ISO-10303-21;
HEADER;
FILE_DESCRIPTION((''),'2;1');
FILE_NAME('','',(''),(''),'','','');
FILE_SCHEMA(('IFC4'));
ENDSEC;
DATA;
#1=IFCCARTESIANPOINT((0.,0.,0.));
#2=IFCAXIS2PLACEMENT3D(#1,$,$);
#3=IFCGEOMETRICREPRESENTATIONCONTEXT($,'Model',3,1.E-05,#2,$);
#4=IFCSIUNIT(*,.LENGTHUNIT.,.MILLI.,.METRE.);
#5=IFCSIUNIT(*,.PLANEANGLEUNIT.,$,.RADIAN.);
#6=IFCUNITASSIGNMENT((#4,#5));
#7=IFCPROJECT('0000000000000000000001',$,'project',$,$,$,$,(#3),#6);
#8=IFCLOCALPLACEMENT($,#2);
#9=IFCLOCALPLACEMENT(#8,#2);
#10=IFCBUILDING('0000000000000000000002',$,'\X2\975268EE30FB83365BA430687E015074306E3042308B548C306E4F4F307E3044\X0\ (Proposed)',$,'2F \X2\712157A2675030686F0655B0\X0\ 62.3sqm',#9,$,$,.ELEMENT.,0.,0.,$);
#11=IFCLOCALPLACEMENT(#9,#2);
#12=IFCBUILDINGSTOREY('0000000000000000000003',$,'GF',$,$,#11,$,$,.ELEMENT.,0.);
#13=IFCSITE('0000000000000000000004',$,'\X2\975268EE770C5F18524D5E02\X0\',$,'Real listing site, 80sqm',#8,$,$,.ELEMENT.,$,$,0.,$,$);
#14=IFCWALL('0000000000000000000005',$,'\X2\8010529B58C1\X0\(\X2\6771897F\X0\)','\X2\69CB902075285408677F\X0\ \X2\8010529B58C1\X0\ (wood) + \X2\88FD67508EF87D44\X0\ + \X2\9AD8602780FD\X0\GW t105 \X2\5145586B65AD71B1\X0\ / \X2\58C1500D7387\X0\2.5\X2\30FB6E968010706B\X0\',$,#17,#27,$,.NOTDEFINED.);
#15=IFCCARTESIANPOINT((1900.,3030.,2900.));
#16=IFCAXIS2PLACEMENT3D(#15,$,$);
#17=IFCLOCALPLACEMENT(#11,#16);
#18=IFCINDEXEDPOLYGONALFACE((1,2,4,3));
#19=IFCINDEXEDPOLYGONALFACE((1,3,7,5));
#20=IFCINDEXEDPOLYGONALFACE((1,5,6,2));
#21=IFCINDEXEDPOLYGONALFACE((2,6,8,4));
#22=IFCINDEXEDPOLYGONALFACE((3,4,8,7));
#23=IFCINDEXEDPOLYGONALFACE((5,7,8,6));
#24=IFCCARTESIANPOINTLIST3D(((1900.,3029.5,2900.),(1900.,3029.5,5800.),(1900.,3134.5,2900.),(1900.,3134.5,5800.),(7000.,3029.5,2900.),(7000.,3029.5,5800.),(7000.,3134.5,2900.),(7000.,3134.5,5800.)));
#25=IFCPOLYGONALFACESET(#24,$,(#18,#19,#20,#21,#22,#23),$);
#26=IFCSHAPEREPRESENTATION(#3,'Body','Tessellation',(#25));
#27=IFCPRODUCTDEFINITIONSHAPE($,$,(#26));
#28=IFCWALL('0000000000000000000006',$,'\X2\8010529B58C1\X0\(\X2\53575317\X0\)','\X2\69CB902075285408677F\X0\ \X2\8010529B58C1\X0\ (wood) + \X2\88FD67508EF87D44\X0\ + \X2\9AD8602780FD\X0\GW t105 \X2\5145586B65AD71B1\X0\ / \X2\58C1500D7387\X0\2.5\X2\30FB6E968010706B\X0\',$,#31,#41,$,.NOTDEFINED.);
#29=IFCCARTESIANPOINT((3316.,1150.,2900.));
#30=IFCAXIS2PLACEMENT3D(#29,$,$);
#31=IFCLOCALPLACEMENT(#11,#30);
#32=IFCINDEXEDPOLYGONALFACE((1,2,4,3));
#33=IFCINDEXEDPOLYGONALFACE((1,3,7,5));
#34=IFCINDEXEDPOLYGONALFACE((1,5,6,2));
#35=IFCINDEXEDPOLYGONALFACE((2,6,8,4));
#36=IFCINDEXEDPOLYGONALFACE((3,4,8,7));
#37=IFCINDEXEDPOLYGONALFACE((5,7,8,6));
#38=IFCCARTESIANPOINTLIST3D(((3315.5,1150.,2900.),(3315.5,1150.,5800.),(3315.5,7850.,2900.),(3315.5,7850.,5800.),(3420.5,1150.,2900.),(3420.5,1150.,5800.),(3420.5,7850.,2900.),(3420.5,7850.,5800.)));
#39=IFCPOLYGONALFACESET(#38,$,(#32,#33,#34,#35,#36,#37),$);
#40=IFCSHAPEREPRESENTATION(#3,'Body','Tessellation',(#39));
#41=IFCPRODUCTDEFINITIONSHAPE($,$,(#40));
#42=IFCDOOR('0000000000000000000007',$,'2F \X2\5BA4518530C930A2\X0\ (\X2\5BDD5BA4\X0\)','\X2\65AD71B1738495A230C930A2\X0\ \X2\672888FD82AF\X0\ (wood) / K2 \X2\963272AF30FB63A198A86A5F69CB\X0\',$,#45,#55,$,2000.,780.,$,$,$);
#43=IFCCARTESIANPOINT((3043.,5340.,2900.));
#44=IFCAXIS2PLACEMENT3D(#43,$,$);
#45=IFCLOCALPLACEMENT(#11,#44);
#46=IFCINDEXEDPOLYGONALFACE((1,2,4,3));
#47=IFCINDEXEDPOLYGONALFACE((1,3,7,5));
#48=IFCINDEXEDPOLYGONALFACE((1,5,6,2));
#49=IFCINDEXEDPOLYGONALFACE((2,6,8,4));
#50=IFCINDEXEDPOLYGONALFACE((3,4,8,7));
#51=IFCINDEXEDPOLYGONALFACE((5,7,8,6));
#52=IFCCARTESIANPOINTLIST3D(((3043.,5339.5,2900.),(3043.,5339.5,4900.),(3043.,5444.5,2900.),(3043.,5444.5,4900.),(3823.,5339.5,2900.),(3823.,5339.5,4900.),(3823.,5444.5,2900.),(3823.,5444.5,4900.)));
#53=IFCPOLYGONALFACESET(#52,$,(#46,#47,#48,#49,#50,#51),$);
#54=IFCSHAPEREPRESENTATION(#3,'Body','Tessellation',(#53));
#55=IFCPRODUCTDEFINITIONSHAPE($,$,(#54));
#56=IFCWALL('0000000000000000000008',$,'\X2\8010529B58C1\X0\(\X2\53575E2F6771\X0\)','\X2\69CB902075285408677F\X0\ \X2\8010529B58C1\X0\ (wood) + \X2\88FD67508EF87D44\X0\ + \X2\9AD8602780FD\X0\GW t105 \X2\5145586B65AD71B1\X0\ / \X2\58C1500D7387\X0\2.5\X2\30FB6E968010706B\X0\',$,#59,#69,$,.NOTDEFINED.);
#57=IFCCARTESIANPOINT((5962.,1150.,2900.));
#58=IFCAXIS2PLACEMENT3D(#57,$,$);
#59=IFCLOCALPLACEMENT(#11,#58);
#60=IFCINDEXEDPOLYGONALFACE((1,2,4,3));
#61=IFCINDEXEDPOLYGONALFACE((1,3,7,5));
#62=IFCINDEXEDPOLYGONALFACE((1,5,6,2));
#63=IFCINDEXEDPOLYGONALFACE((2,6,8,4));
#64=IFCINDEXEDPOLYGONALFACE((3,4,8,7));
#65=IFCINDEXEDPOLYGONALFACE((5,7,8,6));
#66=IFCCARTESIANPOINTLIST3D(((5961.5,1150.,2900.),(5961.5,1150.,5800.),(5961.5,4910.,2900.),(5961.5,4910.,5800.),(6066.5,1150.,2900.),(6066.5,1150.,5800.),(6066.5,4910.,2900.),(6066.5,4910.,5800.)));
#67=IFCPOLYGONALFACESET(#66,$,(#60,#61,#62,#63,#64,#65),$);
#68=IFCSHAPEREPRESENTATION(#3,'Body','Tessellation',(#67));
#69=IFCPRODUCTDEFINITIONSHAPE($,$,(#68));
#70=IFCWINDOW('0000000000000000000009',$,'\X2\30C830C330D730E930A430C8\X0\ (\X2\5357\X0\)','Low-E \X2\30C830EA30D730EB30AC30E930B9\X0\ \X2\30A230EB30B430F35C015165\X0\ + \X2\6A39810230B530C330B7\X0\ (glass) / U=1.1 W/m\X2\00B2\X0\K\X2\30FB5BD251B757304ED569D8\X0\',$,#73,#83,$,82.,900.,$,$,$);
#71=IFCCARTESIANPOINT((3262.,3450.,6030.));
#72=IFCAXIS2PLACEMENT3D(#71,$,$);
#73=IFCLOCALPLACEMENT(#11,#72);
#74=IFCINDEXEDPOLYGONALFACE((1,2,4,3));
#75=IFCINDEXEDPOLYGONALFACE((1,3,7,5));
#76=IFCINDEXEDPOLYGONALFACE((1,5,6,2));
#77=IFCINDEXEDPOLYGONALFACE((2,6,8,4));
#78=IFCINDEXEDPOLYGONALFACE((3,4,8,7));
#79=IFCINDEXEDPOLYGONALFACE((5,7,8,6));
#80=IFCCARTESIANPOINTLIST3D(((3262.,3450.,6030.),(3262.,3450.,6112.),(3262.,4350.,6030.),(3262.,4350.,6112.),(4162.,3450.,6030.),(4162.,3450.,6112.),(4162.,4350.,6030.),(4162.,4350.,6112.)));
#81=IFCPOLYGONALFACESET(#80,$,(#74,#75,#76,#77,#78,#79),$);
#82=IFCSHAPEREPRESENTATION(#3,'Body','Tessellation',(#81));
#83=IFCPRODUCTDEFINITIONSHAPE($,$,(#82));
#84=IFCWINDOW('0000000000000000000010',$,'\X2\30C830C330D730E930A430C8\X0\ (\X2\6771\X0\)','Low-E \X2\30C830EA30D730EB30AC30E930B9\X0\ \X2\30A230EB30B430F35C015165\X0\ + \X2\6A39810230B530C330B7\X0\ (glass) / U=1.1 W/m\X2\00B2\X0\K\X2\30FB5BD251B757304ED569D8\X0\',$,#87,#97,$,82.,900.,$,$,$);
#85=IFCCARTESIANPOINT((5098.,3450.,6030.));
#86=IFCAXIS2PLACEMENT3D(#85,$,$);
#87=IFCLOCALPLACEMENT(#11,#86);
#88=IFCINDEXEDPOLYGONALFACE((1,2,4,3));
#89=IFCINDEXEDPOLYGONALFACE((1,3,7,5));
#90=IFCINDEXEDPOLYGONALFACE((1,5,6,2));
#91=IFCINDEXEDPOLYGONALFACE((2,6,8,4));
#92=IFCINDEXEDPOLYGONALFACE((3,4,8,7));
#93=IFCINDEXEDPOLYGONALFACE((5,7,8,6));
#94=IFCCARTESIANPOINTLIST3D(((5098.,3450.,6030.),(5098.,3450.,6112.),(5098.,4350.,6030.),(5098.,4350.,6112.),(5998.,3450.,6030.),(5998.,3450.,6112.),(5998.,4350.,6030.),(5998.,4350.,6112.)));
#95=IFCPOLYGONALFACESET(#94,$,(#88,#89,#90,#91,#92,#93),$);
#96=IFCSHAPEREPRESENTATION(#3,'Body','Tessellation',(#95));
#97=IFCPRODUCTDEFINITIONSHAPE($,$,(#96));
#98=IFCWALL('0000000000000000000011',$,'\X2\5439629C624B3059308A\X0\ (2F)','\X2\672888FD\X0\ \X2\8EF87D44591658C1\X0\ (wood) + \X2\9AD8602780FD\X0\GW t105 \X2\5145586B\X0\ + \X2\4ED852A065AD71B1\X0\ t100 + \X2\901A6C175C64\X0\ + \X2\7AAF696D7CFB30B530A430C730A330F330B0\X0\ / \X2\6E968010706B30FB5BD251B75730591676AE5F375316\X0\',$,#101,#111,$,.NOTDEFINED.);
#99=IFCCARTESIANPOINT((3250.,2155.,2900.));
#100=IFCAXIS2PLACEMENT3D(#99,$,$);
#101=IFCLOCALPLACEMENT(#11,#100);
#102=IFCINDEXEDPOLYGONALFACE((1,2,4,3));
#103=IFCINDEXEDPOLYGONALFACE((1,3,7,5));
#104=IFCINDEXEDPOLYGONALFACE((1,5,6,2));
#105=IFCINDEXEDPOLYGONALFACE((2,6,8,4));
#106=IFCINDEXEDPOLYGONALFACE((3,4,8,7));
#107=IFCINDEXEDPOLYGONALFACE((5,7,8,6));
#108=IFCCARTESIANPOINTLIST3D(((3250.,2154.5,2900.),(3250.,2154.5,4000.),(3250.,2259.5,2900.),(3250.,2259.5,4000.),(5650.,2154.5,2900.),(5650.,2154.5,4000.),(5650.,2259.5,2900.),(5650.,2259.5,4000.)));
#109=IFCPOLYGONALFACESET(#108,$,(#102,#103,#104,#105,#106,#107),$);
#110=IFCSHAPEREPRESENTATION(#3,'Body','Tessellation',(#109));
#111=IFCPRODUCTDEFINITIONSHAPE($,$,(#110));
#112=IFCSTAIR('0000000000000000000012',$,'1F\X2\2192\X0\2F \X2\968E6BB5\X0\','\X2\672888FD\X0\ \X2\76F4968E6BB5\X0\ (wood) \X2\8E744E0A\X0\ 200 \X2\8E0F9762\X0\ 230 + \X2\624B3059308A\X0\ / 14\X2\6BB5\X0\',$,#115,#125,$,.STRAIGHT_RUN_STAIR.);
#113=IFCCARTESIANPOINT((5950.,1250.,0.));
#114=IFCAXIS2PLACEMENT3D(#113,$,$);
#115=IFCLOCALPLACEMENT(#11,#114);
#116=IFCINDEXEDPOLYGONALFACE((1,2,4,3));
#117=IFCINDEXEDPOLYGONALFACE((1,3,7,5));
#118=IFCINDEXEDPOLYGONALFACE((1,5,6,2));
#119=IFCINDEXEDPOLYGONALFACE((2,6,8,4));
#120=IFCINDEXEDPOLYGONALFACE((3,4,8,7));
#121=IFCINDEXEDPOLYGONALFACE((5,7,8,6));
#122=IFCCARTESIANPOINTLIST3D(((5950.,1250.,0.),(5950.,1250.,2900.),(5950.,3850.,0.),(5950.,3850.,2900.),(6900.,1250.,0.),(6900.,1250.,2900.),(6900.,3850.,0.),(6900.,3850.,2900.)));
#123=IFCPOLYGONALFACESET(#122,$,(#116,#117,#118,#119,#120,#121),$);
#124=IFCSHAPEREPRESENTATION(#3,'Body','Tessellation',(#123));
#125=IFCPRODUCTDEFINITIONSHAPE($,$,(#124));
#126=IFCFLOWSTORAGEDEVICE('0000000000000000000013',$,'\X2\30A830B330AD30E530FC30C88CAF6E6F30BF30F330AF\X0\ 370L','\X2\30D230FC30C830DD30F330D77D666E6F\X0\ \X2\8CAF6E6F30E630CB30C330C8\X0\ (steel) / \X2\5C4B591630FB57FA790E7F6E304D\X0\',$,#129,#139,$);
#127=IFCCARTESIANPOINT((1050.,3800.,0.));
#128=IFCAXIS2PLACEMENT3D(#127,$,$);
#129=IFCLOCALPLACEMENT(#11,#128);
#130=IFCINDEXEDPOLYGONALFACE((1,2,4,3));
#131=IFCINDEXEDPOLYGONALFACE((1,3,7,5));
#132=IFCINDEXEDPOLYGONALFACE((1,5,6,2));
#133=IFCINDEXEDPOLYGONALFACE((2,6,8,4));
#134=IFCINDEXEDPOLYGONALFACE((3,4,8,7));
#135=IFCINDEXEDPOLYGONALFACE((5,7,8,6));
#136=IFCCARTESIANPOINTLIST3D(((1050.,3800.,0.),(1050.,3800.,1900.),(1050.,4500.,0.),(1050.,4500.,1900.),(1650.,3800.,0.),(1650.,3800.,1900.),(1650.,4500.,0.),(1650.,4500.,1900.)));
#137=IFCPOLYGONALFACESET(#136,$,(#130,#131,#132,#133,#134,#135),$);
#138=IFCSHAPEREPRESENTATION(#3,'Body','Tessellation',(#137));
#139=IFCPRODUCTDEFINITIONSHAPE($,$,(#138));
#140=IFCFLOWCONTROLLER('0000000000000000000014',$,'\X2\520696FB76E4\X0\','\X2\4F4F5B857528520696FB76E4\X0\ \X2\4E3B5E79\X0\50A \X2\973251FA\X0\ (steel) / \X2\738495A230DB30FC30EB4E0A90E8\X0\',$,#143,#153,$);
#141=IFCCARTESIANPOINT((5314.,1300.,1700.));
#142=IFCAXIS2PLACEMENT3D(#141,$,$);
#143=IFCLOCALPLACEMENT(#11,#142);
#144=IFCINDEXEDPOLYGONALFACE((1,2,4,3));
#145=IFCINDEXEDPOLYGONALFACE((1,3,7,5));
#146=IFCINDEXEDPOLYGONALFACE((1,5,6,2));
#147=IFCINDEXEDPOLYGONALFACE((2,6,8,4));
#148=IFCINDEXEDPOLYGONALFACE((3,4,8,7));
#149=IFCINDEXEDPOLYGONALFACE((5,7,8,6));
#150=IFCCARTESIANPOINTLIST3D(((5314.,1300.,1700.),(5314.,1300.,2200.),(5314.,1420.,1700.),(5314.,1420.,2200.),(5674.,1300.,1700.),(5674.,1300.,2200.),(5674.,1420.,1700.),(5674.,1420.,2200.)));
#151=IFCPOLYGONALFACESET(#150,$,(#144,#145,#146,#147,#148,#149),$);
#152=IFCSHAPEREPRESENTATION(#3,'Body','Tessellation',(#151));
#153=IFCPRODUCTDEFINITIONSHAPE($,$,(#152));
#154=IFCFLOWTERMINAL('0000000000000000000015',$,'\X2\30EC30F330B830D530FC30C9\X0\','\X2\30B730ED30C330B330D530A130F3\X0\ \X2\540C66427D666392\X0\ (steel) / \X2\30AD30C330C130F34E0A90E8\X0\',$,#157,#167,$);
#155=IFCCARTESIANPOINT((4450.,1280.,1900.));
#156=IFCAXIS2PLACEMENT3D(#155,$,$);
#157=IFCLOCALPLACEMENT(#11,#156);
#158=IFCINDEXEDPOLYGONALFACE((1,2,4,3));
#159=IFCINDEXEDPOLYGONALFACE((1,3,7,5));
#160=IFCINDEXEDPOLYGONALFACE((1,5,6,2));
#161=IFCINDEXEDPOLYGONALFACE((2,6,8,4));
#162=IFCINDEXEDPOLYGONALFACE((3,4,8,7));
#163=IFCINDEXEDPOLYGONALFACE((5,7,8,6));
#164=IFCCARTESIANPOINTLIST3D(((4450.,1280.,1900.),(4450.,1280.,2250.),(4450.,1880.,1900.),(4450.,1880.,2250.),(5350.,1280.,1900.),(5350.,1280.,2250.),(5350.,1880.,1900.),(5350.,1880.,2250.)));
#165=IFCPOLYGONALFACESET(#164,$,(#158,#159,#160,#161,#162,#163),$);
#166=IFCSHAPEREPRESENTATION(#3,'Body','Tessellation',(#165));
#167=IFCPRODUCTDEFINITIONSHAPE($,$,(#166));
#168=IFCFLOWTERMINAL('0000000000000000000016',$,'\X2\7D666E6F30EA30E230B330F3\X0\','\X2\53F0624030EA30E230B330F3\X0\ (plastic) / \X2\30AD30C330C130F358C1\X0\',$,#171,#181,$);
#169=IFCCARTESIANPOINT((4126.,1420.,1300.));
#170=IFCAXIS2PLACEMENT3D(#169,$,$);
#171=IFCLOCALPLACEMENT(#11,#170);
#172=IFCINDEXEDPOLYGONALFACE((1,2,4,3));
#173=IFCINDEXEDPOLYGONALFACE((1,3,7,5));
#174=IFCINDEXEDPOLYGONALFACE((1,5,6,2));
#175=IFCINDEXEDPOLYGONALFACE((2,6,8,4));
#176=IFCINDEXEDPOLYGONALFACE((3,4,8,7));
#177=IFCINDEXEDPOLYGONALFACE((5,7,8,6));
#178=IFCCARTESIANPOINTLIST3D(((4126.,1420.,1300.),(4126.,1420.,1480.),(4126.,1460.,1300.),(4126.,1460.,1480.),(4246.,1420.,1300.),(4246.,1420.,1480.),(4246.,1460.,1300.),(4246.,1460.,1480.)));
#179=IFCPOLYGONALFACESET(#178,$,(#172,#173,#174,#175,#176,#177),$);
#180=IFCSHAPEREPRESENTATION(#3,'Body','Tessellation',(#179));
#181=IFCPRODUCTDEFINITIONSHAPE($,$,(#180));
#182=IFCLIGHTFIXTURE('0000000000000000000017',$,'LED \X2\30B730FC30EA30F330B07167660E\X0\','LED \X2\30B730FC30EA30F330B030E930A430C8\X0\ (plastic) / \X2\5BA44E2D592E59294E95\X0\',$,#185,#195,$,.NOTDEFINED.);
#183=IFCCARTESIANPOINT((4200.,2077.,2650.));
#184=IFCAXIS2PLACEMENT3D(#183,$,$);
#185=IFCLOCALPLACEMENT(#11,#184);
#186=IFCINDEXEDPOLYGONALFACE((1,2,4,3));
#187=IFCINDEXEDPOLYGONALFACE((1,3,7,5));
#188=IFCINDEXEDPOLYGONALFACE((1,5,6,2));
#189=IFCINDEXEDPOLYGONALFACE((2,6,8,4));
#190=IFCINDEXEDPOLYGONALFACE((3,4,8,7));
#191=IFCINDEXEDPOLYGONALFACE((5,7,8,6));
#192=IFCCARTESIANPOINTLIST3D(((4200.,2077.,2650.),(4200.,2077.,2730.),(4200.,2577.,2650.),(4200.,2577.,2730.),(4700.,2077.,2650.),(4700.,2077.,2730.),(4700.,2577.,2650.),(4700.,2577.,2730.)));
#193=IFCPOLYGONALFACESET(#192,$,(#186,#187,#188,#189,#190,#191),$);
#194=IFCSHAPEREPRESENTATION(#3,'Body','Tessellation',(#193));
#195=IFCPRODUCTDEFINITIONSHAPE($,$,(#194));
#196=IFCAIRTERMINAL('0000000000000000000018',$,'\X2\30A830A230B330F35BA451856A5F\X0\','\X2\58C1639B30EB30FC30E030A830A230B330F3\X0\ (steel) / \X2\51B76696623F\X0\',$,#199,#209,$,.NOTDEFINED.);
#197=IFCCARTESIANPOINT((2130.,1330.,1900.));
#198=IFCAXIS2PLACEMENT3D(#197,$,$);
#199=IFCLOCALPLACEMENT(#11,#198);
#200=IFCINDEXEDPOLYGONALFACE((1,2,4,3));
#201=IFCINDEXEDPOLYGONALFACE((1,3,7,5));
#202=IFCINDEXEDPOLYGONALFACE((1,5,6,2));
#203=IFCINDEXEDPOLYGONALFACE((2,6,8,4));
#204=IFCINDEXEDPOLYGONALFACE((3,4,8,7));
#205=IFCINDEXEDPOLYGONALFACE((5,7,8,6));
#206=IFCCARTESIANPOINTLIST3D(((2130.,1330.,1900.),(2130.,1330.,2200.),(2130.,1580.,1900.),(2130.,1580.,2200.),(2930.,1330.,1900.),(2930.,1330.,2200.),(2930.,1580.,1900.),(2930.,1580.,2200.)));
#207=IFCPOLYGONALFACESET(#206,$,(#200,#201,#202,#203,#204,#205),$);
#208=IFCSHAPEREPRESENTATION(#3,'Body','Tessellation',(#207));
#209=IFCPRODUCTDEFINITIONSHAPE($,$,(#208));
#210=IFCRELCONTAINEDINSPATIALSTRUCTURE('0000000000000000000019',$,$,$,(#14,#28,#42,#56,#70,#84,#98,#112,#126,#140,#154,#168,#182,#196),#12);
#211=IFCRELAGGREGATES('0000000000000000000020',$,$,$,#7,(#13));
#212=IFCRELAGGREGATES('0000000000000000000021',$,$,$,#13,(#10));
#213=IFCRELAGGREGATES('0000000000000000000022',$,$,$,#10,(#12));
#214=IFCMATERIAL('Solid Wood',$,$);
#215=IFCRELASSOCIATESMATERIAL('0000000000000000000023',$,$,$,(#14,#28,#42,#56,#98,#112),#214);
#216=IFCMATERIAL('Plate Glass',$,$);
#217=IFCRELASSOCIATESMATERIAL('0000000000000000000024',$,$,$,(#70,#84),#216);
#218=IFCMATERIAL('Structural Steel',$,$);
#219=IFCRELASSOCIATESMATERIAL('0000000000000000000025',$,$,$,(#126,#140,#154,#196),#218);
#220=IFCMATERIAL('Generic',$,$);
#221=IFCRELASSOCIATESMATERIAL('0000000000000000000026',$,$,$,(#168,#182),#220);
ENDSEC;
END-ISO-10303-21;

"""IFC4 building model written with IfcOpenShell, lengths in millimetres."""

from ifc_helpers import new_model, si_unit, frame, frame_2d, origin, place, context, project, spatial, rectangle, extrude, material, element, fill, save


model = new_model("IFC4")

# Units and contexts
model_context = context("Model", 3, precision=1e-05, world=origin())
ifc_project = project(units=[si_unit("LENGTHUNIT", "METRE", prefix="MILLI"), si_unit("PLANEANGLEUNIT", "RADIAN")], contexts=[model_context])

# Site, building, storey
site_placement = place(None, origin())
site = spatial("IfcSite", under=ifc_project, at=site_placement, Name="青森県弘前市", ObjectType="Real listing site, 80sqm", CompositionType="ELEMENT", RefElevation=0.0)
building_placement = place(site_placement, origin())
building = spatial("IfcBuilding", under=site, at=building_placement, Name="青森・茶室と縁側のある和の住まい (Proposed)", ObjectType="2F 無垢材と漆喰 62.3sqm", CompositionType="ELEMENT", ElevationOfRefHeight=0.0, ElevationOfTerrain=0.0)
storey_placement = place(building_placement, origin())
storey = spatial("IfcBuildingStorey", under=building, at=storey_placement, Name="GF", CompositionType="ELEMENT", Elevation=0.0)

# Shared definitions
ifc_material_1 = material(Name="Solid Wood")

# Wall
wall_1_placement = place(storey_placement, frame((1900.0, 3030.0, 2900.0)))
element("IfcWall", 1, at=wall_1_placement, inside=storey, material=ifc_material_1, Name="耐力壁(東西)", Description="構造用合板 耐力壁 (wood) + 製材軸組 + 高性能GW t105 充填断熱 / 壁倍率2.5・準耐火", PredefinedType="NOTDEFINED", context=model_context, shape_type="SweptSolid", body=[
    extrude(rectangle(XDim=5100.0, YDim=105.0, at=frame_2d((2550.0, 52.0))), frame((1900.0, 3030.0, 2900.0)), (0.0, 0.0, 1.0), 2900.0),
])

# Wall, opening, door
wall_2_placement = place(storey_placement, frame((3316.0, 1150.0, 2900.0)))
wall_2 = element("IfcWall", 2, at=wall_2_placement, inside=storey, material=ifc_material_1, Name="耐力壁(南北)", Description="構造用合板 耐力壁 (wood) + 製材軸組 + 高性能GW t105 充填断熱 / 壁倍率2.5・準耐火", PredefinedType="NOTDEFINED", context=model_context, shape_type="SweptSolid", body=[
    extrude(rectangle(XDim=105.0, YDim=6700.0, at=frame_2d((52.0, 3350.0))), frame((3316.0, 1150.0, 2900.0)), (0.0, 0.0, 1.0), 2900.0),
])
opening_placement = place(storey_placement, frame((3043.0, 5340.0, 2900.0)))
opening = element("IfcOpeningElement", 3, at=opening_placement, cuts=wall_2, PredefinedType="NOTDEFINED", context=model_context, shape_type="SweptSolid", body=[
    extrude(rectangle(XDim=780.0, YDim=105.0, at=frame_2d((390.0, 52.0))), frame((3043.0, 5340.0, 2900.0)), (0.0, 0.0, 1.0), 2000.0),
])
door_placement = place(storey_placement, frame((3043.0, 5340.0, 2900.0)))
door = element("IfcDoor", 4, at=door_placement, inside=storey, material=ifc_material_1, Name="2F 室内ドア (寝室)", Description="断熱玄関ドア 木製芯 (wood) / K2 防犯・採風機構", OverallHeight=2000.0, OverallWidth=780.0, context=model_context, shape_type="SweptSolid", body=[
    extrude(rectangle(XDim=780.0, YDim=105.0, at=frame_2d((390.0, 52.0))), frame((3043.0, 5340.0, 2900.0)), (0.0, 0.0, 1.0), 2000.0),
])
fill(opening, door)

# Wall
wall_3_placement = place(storey_placement, frame((5962.0, 1150.0, 2900.0)))
element("IfcWall", 5, at=wall_3_placement, inside=storey, material=ifc_material_1, Name="耐力壁(南帯東)", Description="構造用合板 耐力壁 (wood) + 製材軸組 + 高性能GW t105 充填断熱 / 壁倍率2.5・準耐火", PredefinedType="NOTDEFINED", context=model_context, shape_type="SweptSolid", body=[
    extrude(rectangle(XDim=105.0, YDim=3760.0, at=frame_2d((52.0, 1880.0))), frame((5962.0, 1150.0, 2900.0)), (0.0, 0.0, 1.0), 2900.0),
])

# Windows
ifc_material_2 = material(Name="Plate Glass")
window_1_placement = place(storey_placement, frame((3262.0, 3450.0, 6030.0)))
element("IfcWindow", 6, at=window_1_placement, inside=storey, material=ifc_material_2, Name="トップライト (南)", Description="Low-E トリプルガラス アルゴン封入 + 樹脂サッシ (glass) / U=1.1 W/m²K・寒冷地仕様", OverallHeight=82.0, OverallWidth=900.0, context=model_context, shape_type="SweptSolid", body=[
    extrude(rectangle(XDim=900.0, YDim=900.0, at=frame_2d((450.0, 450.0))), frame((3262.0, 3450.0, 6030.0)), (0.0, 0.0, 1.0), 82.0),
])
window_2_placement = place(storey_placement, frame((5098.0, 3450.0, 6030.0)))
element("IfcWindow", 7, at=window_2_placement, inside=storey, material=ifc_material_2, Name="トップライト (東)", Description="Low-E トリプルガラス アルゴン封入 + 樹脂サッシ (glass) / U=1.1 W/m²K・寒冷地仕様", OverallHeight=82.0, OverallWidth=900.0, context=model_context, shape_type="SweptSolid", body=[
    extrude(rectangle(XDim=900.0, YDim=900.0, at=frame_2d((450.0, 450.0))), frame((5098.0, 3450.0, 6030.0)), (0.0, 0.0, 1.0), 82.0),
])

# Wall
wall_4_placement = place(storey_placement, frame((3250.0, 2155.0, 2900.0)))
element("IfcWall", 8, at=wall_4_placement, inside=storey, material=ifc_material_1, Name="吹抜手すり (2F)", Description="木製 軸組外壁 (wood) + 高性能GW t105 充填 + 付加断熱 t100 + 通気層 + 窯業系サイディング / 準耐火・寒冷地外皮強化", PredefinedType="NOTDEFINED", context=model_context, shape_type="SweptSolid", body=[
    extrude(rectangle(XDim=2400.0, YDim=105.0, at=frame_2d((1200.0, 52.0))), frame((3250.0, 2155.0, 2900.0)), (0.0, 0.0, 1.0), 1100.0),
])

# Stair
stair_placement = place(storey_placement, frame((5950.0, 1250.0, 0.0)))
element("IfcStair", 9, at=stair_placement, inside=storey, material=ifc_material_1, Name="1F→2F 階段", Description="木製 直階段 (wood) 蹴上 200 踏面 230 + 手すり / 14段", PredefinedType="STRAIGHT_RUN_STAIR", context=model_context, shape_type="SweptSolid", body=[
    extrude(rectangle(XDim=950.0, YDim=2600.0, at=frame_2d((475.0, 1300.0))), frame((5950.0, 1250.0, 0.0)), (0.0, 0.0, 1.0), 2900.0),
])

# Flow storage device
ifc_material_3 = material(Name="Structural Steel")
flow_storage_device_placement = place(storey_placement, frame((1050.0, 3800.0, 0.0)))
element("IfcFlowStorageDevice", 10, at=flow_storage_device_placement, inside=storey, material=ifc_material_3, Name="エコキュート貯湯タンク 370L", Description="ヒートポンプ給湯 貯湯ユニット (steel) / 屋外・基礎置き", context=model_context, shape_type="SweptSolid", body=[
    extrude(rectangle(XDim=600.0, YDim=700.0, at=frame_2d((300.0, 350.0))), frame((1050.0, 3800.0, 0.0)), (0.0, 0.0, 1.0), 1900.0),
])

# Flow controller
flow_controller_placement = place(storey_placement, frame((5314.0, 1300.0, 1700.0)))
element("IfcFlowController", 11, at=flow_controller_placement, inside=storey, material=ifc_material_3, Name="分電盤", Description="住宅用分電盤 主幹50A 露出 (steel) / 玄関ホール上部", context=model_context, shape_type="SweptSolid", body=[
    extrude(rectangle(XDim=360.0, YDim=120.0, at=frame_2d((180.0, 60.0))), frame((5314.0, 1300.0, 1700.0)), (0.0, 0.0, 1.0), 500.0),
])

# Flow terminals
flow_terminal_1_placement = place(storey_placement, frame((4450.0, 1280.0, 1900.0)))
element("IfcFlowTerminal", 12, at=flow_terminal_1_placement, inside=storey, material=ifc_material_3, Name="レンジフード", Description="シロッコファン 同時給排 (steel) / キッチン上部", context=model_context, shape_type="SweptSolid", body=[
    extrude(rectangle(XDim=900.0, YDim=600.0, at=frame_2d((450.0, 300.0))), frame((4450.0, 1280.0, 1900.0)), (0.0, 0.0, 1.0), 350.0),
])
ifc_material_4 = material(Name="Generic")
flow_terminal_2_placement = place(storey_placement, frame((4126.0, 1420.0, 1300.0)))
element("IfcFlowTerminal", 13, at=flow_terminal_2_placement, inside=storey, material=ifc_material_4, Name="給湯リモコン", Description="台所リモコン (plastic) / キッチン壁", context=model_context, shape_type="SweptSolid", body=[
    extrude(rectangle(XDim=120.0, YDim=40.0, at=frame_2d((60.0, 20.0))), frame((4126.0, 1420.0, 1300.0)), (0.0, 0.0, 1.0), 180.0),
])

# Light fixture
light_fixture_1_placement = place(storey_placement, frame((4200.0, 2077.0, 2650.0)))
element("IfcLightFixture", 14, at=light_fixture_1_placement, inside=storey, material=ifc_material_4, Name="LED シーリング照明", Description="LED シーリングライト (plastic) / 室中央天井", PredefinedType="NOTDEFINED", context=model_context, shape_type="SweptSolid", body=[
    extrude(rectangle(XDim=500.0, YDim=500.0, at=frame_2d((250.0, 250.0))), frame((4200.0, 2077.0, 2650.0)), (0.0, 0.0, 1.0), 80.0),
])

# Air terminal
air_terminal_1_placement = place(storey_placement, frame((2130.0, 1330.0, 1900.0)))
element("IfcAirTerminal", 15, at=air_terminal_1_placement, inside=storey, material=ifc_material_3, Name="エアコン室内機", Description="壁掛ルームエアコン (steel) / 冷暖房", PredefinedType="NOTDEFINED", context=model_context, shape_type="SweptSolid", body=[
    extrude(rectangle(XDim=800.0, YDim=250.0, at=frame_2d((400.0, 125.0))), frame((2130.0, 1330.0, 1900.0)), (0.0, 0.0, 1.0), 300.0),
])

save(model, "model.ifc")
